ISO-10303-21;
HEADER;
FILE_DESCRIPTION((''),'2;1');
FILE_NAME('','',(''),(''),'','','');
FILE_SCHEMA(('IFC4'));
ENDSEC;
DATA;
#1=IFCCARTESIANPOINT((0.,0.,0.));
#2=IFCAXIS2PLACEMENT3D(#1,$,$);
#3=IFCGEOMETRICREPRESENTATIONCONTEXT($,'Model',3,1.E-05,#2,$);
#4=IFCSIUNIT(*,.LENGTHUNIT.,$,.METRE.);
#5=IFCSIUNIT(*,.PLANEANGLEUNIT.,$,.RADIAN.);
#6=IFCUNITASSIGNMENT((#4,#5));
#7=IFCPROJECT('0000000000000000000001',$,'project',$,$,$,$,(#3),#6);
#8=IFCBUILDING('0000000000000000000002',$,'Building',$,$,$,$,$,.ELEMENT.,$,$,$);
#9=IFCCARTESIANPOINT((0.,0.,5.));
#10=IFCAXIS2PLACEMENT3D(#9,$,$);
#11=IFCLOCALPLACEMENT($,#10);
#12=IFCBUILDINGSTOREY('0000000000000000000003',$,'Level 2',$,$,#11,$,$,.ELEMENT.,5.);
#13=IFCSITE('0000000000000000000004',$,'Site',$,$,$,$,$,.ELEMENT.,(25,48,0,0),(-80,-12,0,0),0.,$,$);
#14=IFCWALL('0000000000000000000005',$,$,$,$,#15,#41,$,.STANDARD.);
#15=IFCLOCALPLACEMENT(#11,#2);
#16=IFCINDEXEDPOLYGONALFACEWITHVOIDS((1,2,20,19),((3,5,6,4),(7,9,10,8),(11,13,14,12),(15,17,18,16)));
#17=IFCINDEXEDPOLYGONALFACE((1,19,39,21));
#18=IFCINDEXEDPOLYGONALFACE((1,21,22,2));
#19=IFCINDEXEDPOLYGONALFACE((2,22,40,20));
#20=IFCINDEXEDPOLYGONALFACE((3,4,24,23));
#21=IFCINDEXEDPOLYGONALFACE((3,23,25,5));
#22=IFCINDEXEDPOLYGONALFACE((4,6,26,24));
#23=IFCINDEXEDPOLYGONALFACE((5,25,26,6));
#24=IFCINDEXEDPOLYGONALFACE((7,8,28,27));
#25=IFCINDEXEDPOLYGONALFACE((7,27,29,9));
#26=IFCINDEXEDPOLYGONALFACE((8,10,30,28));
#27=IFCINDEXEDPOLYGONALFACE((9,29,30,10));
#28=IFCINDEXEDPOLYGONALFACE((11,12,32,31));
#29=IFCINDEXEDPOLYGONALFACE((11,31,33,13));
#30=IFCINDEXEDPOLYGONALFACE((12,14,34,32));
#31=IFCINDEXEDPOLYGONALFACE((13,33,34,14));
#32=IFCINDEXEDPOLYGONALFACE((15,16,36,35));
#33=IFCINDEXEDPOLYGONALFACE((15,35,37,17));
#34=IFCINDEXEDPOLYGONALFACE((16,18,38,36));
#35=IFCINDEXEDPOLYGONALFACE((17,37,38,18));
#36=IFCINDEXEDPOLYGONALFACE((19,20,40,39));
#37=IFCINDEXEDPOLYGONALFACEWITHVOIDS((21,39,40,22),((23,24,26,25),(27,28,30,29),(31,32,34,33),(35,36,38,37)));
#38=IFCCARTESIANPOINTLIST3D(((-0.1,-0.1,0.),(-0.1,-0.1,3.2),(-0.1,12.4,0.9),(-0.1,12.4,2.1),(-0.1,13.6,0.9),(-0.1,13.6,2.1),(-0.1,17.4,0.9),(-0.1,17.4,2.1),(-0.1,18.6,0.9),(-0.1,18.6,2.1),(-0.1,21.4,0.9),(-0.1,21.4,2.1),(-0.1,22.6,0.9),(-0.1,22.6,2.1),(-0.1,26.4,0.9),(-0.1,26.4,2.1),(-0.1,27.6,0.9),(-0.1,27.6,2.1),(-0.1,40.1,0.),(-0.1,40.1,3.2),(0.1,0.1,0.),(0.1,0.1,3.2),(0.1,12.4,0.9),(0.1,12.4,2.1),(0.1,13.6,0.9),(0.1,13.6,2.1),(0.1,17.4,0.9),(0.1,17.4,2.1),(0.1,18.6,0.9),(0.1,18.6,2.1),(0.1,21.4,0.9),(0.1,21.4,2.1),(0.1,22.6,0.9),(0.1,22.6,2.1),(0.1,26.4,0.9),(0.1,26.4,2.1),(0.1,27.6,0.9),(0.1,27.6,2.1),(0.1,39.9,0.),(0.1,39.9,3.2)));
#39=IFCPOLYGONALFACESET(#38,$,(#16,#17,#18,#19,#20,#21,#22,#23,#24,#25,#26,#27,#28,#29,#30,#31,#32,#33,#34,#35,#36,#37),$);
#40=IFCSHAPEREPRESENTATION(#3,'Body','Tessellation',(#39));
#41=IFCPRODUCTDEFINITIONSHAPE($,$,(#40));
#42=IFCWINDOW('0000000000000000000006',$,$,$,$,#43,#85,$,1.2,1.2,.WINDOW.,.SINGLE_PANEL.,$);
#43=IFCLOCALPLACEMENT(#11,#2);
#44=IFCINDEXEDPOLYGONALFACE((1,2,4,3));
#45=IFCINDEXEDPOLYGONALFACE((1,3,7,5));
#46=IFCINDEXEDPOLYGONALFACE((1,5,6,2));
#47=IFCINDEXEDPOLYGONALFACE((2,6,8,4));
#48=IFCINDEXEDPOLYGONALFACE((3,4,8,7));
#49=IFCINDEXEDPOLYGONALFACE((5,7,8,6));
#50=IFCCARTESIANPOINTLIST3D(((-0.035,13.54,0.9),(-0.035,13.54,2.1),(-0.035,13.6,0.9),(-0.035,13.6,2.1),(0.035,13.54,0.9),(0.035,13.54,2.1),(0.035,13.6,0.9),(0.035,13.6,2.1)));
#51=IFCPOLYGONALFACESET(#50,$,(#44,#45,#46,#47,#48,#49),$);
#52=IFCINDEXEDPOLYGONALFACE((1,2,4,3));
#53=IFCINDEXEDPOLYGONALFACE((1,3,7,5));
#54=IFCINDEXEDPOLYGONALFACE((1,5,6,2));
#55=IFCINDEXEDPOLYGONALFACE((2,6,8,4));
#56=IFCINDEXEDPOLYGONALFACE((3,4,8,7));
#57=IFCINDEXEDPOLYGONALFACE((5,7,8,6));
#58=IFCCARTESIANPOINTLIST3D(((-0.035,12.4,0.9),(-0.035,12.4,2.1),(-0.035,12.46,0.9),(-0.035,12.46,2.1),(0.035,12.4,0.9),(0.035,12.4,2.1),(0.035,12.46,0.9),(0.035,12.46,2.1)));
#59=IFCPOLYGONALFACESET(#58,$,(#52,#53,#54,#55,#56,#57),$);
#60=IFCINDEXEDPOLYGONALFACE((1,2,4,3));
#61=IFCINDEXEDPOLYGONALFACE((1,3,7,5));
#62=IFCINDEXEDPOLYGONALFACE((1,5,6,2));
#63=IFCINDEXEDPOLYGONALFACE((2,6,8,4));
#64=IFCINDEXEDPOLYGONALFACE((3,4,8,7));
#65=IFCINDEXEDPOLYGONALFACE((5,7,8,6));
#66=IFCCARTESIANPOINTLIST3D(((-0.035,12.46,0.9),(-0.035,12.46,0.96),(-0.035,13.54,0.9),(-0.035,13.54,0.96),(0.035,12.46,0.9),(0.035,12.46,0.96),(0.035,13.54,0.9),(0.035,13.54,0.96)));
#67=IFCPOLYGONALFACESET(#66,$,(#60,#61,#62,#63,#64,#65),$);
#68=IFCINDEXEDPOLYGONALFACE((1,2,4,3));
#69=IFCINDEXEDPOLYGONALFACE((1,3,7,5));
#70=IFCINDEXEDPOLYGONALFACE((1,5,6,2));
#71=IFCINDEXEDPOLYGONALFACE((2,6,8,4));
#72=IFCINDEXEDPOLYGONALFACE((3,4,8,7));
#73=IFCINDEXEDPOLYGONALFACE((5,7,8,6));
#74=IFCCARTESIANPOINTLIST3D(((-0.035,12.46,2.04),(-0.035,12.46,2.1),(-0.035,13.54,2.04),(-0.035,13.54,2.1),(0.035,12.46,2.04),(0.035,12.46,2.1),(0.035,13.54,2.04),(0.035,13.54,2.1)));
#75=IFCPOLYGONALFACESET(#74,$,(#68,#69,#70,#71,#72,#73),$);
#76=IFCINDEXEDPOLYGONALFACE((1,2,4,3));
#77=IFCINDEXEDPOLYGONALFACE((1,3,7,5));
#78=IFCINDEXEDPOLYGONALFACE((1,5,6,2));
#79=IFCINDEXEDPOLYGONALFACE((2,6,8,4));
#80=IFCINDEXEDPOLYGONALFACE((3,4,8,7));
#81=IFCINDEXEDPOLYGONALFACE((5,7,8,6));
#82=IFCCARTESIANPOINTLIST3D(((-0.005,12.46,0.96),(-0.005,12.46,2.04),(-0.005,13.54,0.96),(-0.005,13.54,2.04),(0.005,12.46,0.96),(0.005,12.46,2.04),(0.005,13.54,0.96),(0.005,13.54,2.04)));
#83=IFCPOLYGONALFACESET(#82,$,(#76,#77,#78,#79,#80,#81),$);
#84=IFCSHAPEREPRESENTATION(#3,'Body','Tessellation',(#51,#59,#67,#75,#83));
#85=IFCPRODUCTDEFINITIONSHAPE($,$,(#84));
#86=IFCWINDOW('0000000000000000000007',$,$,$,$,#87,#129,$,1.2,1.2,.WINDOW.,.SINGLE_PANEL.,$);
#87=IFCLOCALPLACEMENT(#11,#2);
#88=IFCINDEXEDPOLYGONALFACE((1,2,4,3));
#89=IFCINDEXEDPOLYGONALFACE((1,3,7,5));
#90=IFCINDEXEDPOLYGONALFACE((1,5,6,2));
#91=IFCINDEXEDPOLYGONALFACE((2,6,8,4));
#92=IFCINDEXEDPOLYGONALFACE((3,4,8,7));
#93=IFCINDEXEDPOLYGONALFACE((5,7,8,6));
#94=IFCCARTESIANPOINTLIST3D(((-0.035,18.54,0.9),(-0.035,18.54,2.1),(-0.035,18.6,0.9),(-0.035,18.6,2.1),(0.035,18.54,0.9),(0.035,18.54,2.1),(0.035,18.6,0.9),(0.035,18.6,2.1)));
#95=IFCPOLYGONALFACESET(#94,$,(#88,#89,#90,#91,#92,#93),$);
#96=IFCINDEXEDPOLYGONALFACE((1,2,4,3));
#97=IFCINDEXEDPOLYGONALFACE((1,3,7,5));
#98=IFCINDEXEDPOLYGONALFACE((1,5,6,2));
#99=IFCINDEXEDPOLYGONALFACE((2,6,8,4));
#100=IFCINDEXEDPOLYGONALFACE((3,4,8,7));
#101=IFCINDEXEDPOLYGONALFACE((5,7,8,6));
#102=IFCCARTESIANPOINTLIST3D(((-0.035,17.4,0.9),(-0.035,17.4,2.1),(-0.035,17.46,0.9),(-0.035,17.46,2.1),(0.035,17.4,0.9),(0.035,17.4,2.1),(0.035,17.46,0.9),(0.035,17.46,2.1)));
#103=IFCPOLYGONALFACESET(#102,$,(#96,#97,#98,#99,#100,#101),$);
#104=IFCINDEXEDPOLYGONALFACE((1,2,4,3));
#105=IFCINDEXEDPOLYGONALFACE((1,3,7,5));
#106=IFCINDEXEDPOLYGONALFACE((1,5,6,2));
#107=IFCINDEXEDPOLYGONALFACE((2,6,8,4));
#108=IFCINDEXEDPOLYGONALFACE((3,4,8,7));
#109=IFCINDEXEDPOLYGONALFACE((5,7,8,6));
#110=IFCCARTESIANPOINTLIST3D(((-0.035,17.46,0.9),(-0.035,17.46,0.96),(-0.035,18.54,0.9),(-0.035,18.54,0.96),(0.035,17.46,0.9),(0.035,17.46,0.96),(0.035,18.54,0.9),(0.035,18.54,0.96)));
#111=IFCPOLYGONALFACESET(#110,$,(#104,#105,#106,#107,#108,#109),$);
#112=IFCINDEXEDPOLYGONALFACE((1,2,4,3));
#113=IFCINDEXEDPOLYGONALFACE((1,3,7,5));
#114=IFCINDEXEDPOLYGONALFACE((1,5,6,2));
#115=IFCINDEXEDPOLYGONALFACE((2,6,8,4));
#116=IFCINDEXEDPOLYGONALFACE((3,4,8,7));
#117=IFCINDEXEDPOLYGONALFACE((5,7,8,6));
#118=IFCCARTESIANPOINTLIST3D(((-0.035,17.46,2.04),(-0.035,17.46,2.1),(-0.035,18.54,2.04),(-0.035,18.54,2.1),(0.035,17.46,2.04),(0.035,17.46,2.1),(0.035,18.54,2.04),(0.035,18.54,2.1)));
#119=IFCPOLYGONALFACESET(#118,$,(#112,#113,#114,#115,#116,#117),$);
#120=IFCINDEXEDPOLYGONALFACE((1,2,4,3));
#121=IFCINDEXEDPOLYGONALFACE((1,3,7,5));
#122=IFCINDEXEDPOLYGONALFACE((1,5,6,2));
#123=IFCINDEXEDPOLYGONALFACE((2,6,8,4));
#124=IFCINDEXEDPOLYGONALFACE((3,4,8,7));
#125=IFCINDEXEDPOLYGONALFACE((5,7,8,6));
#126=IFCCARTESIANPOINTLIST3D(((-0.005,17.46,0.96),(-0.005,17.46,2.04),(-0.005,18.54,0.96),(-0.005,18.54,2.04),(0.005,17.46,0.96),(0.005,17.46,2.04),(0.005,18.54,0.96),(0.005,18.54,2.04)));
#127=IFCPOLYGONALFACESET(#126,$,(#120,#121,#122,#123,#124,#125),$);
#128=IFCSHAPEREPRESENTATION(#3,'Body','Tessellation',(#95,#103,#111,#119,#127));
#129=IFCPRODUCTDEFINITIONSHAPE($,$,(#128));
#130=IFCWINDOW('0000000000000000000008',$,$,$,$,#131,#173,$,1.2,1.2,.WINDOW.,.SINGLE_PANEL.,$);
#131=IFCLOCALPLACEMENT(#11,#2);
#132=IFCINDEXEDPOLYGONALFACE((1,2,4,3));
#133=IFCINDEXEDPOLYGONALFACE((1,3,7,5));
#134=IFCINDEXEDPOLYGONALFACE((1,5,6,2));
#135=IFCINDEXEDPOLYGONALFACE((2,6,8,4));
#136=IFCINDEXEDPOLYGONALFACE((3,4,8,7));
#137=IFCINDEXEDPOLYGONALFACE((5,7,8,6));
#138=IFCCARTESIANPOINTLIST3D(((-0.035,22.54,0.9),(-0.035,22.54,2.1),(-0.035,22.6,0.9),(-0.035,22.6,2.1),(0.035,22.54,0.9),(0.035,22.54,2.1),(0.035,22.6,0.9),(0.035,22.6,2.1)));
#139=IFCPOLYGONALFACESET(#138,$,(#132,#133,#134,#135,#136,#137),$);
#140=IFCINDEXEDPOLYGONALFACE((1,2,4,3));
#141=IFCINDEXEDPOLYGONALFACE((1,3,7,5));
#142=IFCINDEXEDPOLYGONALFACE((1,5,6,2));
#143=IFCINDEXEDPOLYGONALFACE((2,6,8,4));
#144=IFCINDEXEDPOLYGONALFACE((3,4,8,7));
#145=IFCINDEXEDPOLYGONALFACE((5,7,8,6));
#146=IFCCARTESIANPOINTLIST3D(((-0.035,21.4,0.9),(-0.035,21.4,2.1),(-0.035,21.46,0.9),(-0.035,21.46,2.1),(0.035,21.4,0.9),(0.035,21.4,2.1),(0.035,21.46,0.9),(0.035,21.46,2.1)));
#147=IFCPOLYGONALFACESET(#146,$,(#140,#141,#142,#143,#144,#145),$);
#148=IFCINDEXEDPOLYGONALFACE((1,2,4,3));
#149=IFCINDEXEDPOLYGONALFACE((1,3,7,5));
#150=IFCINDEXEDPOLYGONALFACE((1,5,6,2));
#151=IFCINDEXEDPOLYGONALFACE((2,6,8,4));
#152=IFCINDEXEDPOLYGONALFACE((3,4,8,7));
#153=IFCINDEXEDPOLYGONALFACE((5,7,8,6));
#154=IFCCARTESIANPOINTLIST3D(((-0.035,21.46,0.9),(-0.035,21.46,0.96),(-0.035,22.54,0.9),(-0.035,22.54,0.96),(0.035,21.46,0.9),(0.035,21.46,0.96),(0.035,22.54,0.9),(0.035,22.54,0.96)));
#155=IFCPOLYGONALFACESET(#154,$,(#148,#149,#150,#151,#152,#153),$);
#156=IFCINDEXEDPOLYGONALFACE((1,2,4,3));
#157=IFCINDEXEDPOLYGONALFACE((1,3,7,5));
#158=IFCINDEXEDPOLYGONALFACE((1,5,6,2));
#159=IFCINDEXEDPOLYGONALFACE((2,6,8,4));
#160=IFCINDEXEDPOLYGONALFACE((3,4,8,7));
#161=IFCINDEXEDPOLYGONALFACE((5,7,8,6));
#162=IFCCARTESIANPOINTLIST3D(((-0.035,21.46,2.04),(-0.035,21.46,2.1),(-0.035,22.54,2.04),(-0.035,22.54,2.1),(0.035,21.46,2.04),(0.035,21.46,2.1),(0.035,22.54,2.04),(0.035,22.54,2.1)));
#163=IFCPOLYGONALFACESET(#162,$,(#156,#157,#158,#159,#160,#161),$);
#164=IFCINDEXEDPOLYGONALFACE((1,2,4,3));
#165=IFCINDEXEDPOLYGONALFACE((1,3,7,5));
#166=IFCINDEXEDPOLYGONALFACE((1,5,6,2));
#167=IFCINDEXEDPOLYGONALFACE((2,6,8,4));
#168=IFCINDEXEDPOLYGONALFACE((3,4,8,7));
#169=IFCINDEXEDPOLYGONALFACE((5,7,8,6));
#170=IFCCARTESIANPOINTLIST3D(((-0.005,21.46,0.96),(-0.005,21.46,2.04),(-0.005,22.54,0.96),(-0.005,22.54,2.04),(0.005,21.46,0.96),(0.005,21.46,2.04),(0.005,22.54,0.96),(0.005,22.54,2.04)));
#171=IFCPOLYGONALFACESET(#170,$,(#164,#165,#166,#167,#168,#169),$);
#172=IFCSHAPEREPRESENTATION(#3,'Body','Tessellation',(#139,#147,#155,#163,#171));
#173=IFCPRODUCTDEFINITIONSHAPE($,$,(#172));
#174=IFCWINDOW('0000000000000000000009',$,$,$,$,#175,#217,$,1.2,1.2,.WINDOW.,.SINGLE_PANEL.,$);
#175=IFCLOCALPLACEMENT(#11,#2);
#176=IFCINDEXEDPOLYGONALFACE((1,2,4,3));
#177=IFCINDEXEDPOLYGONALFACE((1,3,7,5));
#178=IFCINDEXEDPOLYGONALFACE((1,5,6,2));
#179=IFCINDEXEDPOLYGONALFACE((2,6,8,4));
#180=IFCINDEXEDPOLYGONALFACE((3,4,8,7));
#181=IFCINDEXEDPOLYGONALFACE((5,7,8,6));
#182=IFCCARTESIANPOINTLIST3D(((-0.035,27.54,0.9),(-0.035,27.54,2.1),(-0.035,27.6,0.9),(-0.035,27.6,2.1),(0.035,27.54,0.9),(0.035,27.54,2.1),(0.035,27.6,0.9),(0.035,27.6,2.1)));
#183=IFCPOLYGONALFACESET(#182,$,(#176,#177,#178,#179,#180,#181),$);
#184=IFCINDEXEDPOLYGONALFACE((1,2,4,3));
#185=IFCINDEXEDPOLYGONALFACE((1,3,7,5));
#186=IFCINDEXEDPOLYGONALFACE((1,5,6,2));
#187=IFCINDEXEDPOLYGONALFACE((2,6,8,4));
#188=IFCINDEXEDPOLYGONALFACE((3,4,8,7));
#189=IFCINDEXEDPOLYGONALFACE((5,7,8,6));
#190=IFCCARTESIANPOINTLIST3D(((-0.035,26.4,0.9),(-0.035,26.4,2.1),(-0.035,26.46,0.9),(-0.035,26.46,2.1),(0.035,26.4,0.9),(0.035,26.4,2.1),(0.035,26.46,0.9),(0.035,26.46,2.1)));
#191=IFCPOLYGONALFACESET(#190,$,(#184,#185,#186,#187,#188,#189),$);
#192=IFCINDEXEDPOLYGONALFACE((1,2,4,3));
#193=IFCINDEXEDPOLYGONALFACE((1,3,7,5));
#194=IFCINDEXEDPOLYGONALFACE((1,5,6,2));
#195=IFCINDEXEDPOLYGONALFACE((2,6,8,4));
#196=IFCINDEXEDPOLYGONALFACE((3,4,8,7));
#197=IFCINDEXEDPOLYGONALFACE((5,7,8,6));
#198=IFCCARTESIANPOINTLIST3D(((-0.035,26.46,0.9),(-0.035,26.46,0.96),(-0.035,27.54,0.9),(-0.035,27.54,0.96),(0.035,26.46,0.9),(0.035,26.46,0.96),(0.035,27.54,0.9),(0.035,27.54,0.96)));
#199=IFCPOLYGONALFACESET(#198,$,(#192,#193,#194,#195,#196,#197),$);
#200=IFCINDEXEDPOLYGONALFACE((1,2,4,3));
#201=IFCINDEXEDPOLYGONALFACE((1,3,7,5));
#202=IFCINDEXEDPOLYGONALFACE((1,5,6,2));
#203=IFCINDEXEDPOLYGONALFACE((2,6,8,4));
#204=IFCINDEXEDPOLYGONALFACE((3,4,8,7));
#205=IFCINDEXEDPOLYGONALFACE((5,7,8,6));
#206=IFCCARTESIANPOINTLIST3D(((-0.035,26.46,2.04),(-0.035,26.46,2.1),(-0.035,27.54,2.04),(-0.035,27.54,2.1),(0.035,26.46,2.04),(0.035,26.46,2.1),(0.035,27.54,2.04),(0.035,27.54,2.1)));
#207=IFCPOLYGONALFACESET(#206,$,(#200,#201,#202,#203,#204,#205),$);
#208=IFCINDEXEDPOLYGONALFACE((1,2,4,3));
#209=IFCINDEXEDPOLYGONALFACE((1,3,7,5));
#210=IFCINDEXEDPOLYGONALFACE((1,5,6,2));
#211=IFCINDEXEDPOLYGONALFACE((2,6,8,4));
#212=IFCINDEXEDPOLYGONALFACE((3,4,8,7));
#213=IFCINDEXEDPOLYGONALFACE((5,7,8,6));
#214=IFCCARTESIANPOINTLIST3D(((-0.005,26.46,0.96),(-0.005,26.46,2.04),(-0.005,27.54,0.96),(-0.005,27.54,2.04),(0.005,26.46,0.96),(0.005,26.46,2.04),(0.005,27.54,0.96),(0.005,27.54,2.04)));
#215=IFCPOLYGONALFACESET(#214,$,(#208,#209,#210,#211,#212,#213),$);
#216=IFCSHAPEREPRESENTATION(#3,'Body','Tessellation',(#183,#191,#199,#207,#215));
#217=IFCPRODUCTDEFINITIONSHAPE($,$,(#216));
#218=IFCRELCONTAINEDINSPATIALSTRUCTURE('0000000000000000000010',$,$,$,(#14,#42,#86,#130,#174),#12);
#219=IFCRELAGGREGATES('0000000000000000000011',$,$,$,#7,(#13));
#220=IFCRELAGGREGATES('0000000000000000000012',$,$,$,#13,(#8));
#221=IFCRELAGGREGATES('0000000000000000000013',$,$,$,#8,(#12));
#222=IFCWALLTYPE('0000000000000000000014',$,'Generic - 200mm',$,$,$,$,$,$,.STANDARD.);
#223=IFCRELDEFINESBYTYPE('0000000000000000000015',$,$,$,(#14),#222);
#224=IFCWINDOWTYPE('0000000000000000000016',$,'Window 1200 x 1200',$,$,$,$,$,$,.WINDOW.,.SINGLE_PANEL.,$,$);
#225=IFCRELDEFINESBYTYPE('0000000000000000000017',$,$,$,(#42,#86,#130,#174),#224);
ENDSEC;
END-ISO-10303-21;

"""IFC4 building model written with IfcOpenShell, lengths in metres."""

from ifc_helpers import new_model, si_unit, frame, frame_2d, origin, origin_with_axes, origin_2d, place, context, project, spatial, polyline, rectangle, outline, extrude, type_object, element, fill, save


model = new_model("IFC4")

# Units and contexts
model_context = context("Model", 3, precision=1e-05, world=origin())
ifc_project = project(units=[si_unit("LENGTHUNIT", "METRE"), si_unit("PLANEANGLEUNIT", "RADIAN")], contexts=[model_context])

# Site, building, storey
site = spatial("IfcSite", under=ifc_project, Name="Site", CompositionType="ELEMENT", RefLatitude=(25, 48, 0, 0), RefLongitude=(-80, -12, 0, 0), RefElevation=0.0)
building = spatial("IfcBuilding", under=site, Name="Building", CompositionType="ELEMENT")
storey_placement = place(None, frame((0.0, 0.0, 5.0)))
storey = spatial("IfcBuildingStorey", under=building, at=storey_placement, Name="Level 2", CompositionType="ELEMENT", Elevation=5.0)

# Wall, openings, windows
wall_type = type_object("IfcWallType", Name="Generic - 200mm", PredefinedType="STANDARD")
wall_1_placement = place(None, frame((0.0, 40.0, 5.0), z_axis=(0.0, 0.0, 1.0), x_axis=(0.0, -1.0, 0.0)))
wall_1 = element("IfcWall", 1, at=wall_1_placement, inside=storey, type_object=wall_type, PredefinedType="STANDARD", context=model_context, shape_type="SweptSolid", body=[
    extrude(outline(polyline([(-0.1, -0.1), (40.1, -0.1), (39.9, 0.1), (0.1, 0.1), (-0.1, -0.1)])), origin(), (0.0, 0.0, 1.0), 3.2),
])
opening_1_placement = place(wall_1_placement, frame((27.0, 0.0, 0.9), z_axis=(0.0, 0.0, 1.0), x_axis=(1.0, 0.0, 0.0)))
opening_1 = element("IfcOpeningElement", 2, at=opening_1_placement, cuts=wall_1, PredefinedType="OPENING", context=model_context, shape_type="SweptSolid", body=[
    extrude(rectangle(XDim=1.2, YDim=0.202, at=origin_2d()), origin(), (0.0, 0.0, 1.0), 1.2),
])
opening_2_placement = place(wall_1_placement, frame((22.0, 0.0, 0.9), z_axis=(0.0, 0.0, 1.0), x_axis=(1.0, 0.0, 0.0)))
opening_2 = element("IfcOpeningElement", 3, at=opening_2_placement, cuts=wall_1, PredefinedType="OPENING", context=model_context, shape_type="SweptSolid", body=[
    extrude(rectangle(XDim=1.2, YDim=0.202, at=origin_2d()), origin(), (0.0, 0.0, 1.0), 1.2),
])
opening_3_placement = place(wall_1_placement, frame((18.0, 0.0, 0.9), z_axis=(0.0, 0.0, 1.0), x_axis=(1.0, 0.0, 0.0)))
opening_3 = element("IfcOpeningElement", 4, at=opening_3_placement, cuts=wall_1, PredefinedType="OPENING", context=model_context, shape_type="SweptSolid", body=[
    extrude(rectangle(XDim=1.2, YDim=0.202, at=origin_2d()), origin(), (0.0, 0.0, 1.0), 1.2),
])
opening_4_placement = place(wall_1_placement, frame((13.0, 0.0, 0.9), z_axis=(0.0, 0.0, 1.0), x_axis=(1.0, 0.0, 0.0)))
opening_4 = element("IfcOpeningElement", 5, at=opening_4_placement, cuts=wall_1, PredefinedType="OPENING", context=model_context, shape_type="SweptSolid", body=[
    extrude(rectangle(XDim=1.2, YDim=0.202, at=origin_2d()), origin(), (0.0, 0.0, 1.0), 1.2),
])
window_type = type_object("IfcWindowType", Name="Window 1200 x 1200", PartitioningType="SINGLE_PANEL", PredefinedType="WINDOW")
window_1_placement = place(opening_1_placement, origin_with_axes())
window_1 = element("IfcWindow", 6, at=window_1_placement, inside=storey, type_object=window_type, OverallHeight=1.2, OverallWidth=1.2, PartitioningType="SINGLE_PANEL", PredefinedType="WINDOW", context=model_context, shape_type="SweptSolid", body=[
    extrude(rectangle(XDim=0.06, YDim=0.07, at=frame_2d((-0.57, 0.0))), origin(), (0.0, 0.0, 1.0), 1.2),
    extrude(rectangle(XDim=0.06, YDim=0.07, at=frame_2d((0.57, 0.0))), origin(), (0.0, 0.0, 1.0), 1.2),
    extrude(rectangle(XDim=1.08, YDim=0.07, at=origin_2d()), origin(), (0.0, 0.0, 1.0), 0.06),
    extrude(rectangle(XDim=1.08, YDim=0.07, at=origin_2d()), frame((0.0, 0.0, 1.14)), (0.0, 0.0, 1.0), 0.06),
    extrude(rectangle(XDim=1.08, YDim=0.01, at=origin_2d()), frame((0.0, 0.0, 0.06)), (0.0, 0.0, 1.0), 1.08),
])
fill(opening_1, window_1)
window_2_placement = place(opening_2_placement, origin_with_axes())
window_2 = element("IfcWindow", 7, at=window_2_placement, inside=storey, type_object=window_type, OverallHeight=1.2, OverallWidth=1.2, PartitioningType="SINGLE_PANEL", PredefinedType="WINDOW", context=model_context, shape_type="SweptSolid", body=[
    extrude(rectangle(XDim=0.06, YDim=0.07, at=frame_2d((-0.57, 0.0))), origin(), (0.0, 0.0, 1.0), 1.2),
    extrude(rectangle(XDim=0.06, YDim=0.07, at=frame_2d((0.57, 0.0))), origin(), (0.0, 0.0, 1.0), 1.2),
    extrude(rectangle(XDim=1.08, YDim=0.07, at=origin_2d()), origin(), (0.0, 0.0, 1.0), 0.06),
    extrude(rectangle(XDim=1.08, YDim=0.07, at=origin_2d()), frame((0.0, 0.0, 1.14)), (0.0, 0.0, 1.0), 0.06),
    extrude(rectangle(XDim=1.08, YDim=0.01, at=origin_2d()), frame((0.0, 0.0, 0.06)), (0.0, 0.0, 1.0), 1.08),
])
fill(opening_2, window_2)
window_3_placement = place(opening_3_placement, origin_with_axes())
window_3 = element("IfcWindow", 8, at=window_3_placement, inside=storey, type_object=window_type, OverallHeight=1.2, OverallWidth=1.2, PartitioningType="SINGLE_PANEL", PredefinedType="WINDOW", context=model_context, shape_type="SweptSolid", body=[
    extrude(rectangle(XDim=0.06, YDim=0.07, at=frame_2d((-0.57, 0.0))), origin(), (0.0, 0.0, 1.0), 1.2),
    extrude(rectangle(XDim=0.06, YDim=0.07, at=frame_2d((0.57, 0.0))), origin(), (0.0, 0.0, 1.0), 1.2),
    extrude(rectangle(XDim=1.08, YDim=0.07, at=origin_2d()), origin(), (0.0, 0.0, 1.0), 0.06),
    extrude(rectangle(XDim=1.08, YDim=0.07, at=origin_2d()), frame((0.0, 0.0, 1.14)), (0.0, 0.0, 1.0), 0.06),
    extrude(rectangle(XDim=1.08, YDim=0.01, at=origin_2d()), frame((0.0, 0.0, 0.06)), (0.0, 0.0, 1.0), 1.08),
])
fill(opening_3, window_3)
window_4_placement = place(opening_4_placement, origin_with_axes())
window_4 = element("IfcWindow", 9, at=window_4_placement, inside=storey, type_object=window_type, OverallHeight=1.2, OverallWidth=1.2, PartitioningType="SINGLE_PANEL", PredefinedType="WINDOW", context=model_context, shape_type="SweptSolid", body=[
    extrude(rectangle(XDim=0.06, YDim=0.07, at=frame_2d((-0.57, 0.0))), origin(), (0.0, 0.0, 1.0), 1.2),
    extrude(rectangle(XDim=0.06, YDim=0.07, at=frame_2d((0.57, 0.0))), origin(), (0.0, 0.0, 1.0), 1.2),
    extrude(rectangle(XDim=1.08, YDim=0.07, at=origin_2d()), origin(), (0.0, 0.0, 1.0), 0.06),
    extrude(rectangle(XDim=1.08, YDim=0.07, at=origin_2d()), frame((0.0, 0.0, 1.14)), (0.0, 0.0, 1.0), 0.06),
    extrude(rectangle(XDim=1.08, YDim=0.01, at=origin_2d()), frame((0.0, 0.0, 0.06)), (0.0, 0.0, 1.0), 1.08),
])
fill(opening_4, window_4)

save(model, "model.ifc")
